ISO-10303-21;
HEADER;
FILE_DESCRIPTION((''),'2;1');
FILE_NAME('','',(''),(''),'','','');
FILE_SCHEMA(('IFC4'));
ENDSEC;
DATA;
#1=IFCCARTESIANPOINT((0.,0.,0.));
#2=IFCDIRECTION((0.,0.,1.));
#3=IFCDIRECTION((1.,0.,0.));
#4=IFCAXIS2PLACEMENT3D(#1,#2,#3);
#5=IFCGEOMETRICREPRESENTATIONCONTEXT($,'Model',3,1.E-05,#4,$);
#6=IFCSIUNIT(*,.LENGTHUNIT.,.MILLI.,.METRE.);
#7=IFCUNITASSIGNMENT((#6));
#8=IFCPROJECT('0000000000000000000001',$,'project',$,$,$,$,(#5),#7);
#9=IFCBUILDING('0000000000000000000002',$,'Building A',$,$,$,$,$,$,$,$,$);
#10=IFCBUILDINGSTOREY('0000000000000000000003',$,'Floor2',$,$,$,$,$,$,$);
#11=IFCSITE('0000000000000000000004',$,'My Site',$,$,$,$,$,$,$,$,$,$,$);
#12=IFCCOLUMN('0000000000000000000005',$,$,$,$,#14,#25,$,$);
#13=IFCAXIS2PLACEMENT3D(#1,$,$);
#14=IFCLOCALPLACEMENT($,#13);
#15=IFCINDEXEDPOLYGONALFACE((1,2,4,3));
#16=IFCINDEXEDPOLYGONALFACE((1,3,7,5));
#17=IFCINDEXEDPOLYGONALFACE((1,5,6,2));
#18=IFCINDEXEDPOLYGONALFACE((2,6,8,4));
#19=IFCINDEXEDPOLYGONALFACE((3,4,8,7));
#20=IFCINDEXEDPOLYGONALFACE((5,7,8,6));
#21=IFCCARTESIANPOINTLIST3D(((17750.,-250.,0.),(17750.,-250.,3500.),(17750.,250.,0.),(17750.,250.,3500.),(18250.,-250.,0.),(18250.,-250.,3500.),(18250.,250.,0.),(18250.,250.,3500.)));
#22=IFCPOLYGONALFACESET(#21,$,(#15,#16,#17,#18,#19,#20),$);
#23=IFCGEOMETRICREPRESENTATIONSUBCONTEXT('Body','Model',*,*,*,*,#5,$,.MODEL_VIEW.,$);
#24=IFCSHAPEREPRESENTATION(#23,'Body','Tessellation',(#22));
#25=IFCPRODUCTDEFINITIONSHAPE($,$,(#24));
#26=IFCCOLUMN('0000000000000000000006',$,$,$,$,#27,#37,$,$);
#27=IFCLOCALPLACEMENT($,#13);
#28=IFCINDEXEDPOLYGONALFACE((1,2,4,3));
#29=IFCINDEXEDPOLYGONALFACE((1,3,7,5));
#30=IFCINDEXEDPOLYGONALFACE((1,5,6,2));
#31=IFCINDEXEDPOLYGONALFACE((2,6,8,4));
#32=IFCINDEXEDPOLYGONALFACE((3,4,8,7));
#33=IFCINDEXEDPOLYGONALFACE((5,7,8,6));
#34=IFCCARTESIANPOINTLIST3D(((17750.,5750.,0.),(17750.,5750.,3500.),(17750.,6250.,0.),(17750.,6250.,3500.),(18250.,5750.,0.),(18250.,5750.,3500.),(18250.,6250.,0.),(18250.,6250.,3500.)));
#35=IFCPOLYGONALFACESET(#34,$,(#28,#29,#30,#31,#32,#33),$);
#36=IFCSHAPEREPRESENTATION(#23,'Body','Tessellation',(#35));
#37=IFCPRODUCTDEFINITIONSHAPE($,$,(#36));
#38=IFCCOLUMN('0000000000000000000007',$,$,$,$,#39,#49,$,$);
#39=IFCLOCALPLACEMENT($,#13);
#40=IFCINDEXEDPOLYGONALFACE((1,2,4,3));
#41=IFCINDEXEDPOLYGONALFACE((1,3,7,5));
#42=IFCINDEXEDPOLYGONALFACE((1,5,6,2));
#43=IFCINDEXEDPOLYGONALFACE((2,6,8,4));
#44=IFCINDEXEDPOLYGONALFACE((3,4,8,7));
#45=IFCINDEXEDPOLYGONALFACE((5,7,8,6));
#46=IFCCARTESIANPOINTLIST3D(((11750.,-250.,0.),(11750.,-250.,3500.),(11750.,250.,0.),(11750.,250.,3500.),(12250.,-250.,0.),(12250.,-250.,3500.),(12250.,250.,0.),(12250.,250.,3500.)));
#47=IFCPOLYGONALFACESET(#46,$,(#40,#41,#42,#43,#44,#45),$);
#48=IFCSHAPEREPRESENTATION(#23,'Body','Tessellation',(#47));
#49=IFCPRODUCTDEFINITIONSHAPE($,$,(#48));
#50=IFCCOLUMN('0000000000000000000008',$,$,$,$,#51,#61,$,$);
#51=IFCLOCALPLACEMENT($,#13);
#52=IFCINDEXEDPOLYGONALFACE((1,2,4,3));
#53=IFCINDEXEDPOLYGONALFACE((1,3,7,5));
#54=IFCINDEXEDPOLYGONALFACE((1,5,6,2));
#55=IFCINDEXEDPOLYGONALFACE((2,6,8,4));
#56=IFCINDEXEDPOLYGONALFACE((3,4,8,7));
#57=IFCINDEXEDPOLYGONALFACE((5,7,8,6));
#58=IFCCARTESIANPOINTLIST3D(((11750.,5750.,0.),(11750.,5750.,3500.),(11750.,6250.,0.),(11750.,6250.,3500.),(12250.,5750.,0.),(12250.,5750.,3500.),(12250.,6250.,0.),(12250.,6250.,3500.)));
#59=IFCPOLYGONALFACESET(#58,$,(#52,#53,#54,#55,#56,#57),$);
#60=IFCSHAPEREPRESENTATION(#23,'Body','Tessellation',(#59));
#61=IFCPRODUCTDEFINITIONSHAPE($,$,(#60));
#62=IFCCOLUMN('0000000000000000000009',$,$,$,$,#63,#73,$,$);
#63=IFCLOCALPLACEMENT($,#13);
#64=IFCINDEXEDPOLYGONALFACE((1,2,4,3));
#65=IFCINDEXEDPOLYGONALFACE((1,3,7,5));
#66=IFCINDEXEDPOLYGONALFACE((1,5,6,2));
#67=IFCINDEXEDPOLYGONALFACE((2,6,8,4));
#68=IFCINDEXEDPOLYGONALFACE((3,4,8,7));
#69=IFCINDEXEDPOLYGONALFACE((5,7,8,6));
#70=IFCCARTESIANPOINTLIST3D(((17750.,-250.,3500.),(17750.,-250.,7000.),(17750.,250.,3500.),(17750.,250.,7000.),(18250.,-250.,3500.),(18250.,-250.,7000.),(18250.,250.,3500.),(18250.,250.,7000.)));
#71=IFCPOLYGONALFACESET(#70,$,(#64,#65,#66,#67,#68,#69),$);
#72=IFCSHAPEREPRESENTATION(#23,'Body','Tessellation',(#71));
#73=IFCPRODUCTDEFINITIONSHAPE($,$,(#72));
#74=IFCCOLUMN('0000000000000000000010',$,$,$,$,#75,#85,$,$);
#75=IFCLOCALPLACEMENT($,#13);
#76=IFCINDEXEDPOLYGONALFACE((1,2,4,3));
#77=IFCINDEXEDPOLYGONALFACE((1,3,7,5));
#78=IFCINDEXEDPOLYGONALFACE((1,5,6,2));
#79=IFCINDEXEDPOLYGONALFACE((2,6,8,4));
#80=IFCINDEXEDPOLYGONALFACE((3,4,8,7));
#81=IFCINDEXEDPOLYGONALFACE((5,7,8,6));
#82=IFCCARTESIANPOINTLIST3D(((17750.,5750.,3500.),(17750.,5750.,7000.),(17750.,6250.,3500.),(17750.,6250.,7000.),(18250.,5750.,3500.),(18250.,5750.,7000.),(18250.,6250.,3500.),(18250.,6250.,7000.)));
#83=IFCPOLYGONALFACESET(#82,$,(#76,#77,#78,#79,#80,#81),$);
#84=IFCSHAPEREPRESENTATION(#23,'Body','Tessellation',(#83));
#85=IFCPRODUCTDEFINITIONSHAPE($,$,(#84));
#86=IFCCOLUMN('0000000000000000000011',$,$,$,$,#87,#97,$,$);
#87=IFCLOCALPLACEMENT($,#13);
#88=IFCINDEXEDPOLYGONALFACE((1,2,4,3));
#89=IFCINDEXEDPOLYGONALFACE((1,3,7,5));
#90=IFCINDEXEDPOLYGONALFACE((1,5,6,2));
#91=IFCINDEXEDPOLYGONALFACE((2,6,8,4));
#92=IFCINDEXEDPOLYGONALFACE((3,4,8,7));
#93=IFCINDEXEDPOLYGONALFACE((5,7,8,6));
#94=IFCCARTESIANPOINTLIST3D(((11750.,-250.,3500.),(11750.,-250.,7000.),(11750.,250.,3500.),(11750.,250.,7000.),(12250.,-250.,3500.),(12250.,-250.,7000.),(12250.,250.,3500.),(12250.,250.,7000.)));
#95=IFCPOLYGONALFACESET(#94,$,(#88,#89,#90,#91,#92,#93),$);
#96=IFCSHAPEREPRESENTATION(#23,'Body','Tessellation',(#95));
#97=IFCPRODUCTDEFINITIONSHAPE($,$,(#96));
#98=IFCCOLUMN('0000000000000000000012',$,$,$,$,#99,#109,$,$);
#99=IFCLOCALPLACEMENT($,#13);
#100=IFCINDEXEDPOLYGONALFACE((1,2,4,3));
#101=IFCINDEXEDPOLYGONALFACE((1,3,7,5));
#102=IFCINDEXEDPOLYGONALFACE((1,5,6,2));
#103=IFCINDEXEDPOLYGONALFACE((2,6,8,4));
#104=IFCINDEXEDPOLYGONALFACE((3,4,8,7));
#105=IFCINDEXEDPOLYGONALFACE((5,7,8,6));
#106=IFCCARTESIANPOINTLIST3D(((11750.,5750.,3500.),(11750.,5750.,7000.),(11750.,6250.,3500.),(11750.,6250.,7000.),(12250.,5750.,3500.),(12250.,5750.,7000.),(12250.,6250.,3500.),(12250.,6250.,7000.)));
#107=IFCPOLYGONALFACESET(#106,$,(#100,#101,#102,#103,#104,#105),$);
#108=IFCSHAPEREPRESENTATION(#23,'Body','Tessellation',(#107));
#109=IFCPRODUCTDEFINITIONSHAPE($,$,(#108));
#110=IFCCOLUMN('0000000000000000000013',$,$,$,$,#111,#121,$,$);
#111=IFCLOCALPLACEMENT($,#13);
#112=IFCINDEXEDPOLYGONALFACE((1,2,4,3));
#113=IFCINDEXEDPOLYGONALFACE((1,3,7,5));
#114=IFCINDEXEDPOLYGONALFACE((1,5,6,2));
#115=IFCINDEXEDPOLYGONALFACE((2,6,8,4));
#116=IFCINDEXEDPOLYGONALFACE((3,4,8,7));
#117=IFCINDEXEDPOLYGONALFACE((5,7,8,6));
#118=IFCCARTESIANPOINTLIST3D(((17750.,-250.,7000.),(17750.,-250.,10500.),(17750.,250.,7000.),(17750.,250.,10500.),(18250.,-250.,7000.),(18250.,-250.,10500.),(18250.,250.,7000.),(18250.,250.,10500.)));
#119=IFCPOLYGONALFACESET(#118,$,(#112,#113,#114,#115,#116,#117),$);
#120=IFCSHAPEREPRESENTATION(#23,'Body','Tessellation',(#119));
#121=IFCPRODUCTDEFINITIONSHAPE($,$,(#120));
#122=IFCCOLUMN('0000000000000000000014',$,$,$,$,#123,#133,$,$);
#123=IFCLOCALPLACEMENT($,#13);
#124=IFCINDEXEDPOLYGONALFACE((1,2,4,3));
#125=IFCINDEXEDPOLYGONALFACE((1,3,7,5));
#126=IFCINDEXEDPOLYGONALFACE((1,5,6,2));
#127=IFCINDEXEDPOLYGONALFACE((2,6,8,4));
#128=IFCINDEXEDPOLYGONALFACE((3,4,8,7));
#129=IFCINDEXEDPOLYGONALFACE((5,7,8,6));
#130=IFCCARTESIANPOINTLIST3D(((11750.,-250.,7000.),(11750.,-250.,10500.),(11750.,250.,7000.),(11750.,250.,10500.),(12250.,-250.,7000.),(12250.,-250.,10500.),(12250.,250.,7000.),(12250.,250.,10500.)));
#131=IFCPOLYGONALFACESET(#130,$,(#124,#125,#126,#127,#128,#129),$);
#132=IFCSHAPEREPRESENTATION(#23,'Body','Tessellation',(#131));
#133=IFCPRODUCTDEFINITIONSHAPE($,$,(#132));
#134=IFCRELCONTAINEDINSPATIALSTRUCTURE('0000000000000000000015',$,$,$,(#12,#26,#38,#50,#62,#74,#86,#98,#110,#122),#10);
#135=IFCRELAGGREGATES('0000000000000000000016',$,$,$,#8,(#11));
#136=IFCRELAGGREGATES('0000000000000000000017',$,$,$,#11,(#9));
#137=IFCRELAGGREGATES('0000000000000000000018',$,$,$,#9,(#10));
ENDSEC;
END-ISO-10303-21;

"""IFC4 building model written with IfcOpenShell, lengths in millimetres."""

from ifc_helpers import new_model, si_unit, frame, origin_with_axes, place, context, subcontext, project, spatial, line, indexed_curve, outline, extrude, element, save


model = new_model("IFC4")

# Units and contexts
model_context = context("Model", 3, precision=1e-05, world=origin_with_axes())
body_context = subcontext(model_context, "Body", "Model", "MODEL_VIEW")
ifc_project = project(units=[si_unit("LENGTHUNIT", "METRE", prefix="MILLI")], contexts=[model_context])

# Site, building, storey
site = spatial("IfcSite", under=ifc_project, Name="My Site")
building = spatial("IfcBuilding", under=site, Name="Building A")
storey = spatial("IfcBuildingStorey", under=building, Name="Floor2")

# Columns
for number, where, z_axis, x_axis in (
    (1, (18000.0, 0.0, 0.0), (0.0, 0.0, 1.0), (1.0, 0.0, 0.0)),
    (2, (18000.0, 6000.0, 0.0), (0.0, 0.0, 1.0), (1.0, 0.0, 0.0)),
    (3, (12000.0, 0.0, 0.0), (0.0, 0.0, 1.0), (1.0, 0.0, 0.0)),
    (4, (12000.0, 6000.0, 0.0), (0.0, 0.0, 1.0), (1.0, 0.0, 0.0)),
    (5, (18000.0, 0.0, 3500.0), (0.0, 0.0, 1.0), (1.0, 0.0, 0.0)),
    (6, (18000.0, 6000.0, 3500.0), (0.0, 0.0, 1.0), (1.0, 0.0, 0.0)),
    (7, (12000.0, 0.0, 3500.0), (0.0, 0.0, 1.0), (1.0, 0.0, 0.0)),
    (8, (12000.0, 6000.0, 3500.0), (0.0, 0.0, 1.0), (1.0, 0.0, 0.0)),
    (9, (18000.0, 0.0, 7000.0), (0.0, 0.0, 1.0), (1.0, 0.0, 0.0)),
    (10, (12000.0, 0.0, 7000.0), (0.0, 0.0, 1.0), (1.0, 0.0, 0.0)),
):
    element("IfcColumn", number, at=place(None, frame(where, z_axis=z_axis, x_axis=x_axis)), inside=storey, context=body_context, shape_type="SweptSolid", body=[
        extrude(outline(indexed_curve([(-250.0, -250.0), (250.0, -250.0), (250.0, 250.0), (-250.0, 250.0)], segments=[line(1, 2, 3, 4, 1)])), origin_with_axes(), (0.0, 0.0, 1.0), 3500.0),
    ])

save(model, "model.ifc")
